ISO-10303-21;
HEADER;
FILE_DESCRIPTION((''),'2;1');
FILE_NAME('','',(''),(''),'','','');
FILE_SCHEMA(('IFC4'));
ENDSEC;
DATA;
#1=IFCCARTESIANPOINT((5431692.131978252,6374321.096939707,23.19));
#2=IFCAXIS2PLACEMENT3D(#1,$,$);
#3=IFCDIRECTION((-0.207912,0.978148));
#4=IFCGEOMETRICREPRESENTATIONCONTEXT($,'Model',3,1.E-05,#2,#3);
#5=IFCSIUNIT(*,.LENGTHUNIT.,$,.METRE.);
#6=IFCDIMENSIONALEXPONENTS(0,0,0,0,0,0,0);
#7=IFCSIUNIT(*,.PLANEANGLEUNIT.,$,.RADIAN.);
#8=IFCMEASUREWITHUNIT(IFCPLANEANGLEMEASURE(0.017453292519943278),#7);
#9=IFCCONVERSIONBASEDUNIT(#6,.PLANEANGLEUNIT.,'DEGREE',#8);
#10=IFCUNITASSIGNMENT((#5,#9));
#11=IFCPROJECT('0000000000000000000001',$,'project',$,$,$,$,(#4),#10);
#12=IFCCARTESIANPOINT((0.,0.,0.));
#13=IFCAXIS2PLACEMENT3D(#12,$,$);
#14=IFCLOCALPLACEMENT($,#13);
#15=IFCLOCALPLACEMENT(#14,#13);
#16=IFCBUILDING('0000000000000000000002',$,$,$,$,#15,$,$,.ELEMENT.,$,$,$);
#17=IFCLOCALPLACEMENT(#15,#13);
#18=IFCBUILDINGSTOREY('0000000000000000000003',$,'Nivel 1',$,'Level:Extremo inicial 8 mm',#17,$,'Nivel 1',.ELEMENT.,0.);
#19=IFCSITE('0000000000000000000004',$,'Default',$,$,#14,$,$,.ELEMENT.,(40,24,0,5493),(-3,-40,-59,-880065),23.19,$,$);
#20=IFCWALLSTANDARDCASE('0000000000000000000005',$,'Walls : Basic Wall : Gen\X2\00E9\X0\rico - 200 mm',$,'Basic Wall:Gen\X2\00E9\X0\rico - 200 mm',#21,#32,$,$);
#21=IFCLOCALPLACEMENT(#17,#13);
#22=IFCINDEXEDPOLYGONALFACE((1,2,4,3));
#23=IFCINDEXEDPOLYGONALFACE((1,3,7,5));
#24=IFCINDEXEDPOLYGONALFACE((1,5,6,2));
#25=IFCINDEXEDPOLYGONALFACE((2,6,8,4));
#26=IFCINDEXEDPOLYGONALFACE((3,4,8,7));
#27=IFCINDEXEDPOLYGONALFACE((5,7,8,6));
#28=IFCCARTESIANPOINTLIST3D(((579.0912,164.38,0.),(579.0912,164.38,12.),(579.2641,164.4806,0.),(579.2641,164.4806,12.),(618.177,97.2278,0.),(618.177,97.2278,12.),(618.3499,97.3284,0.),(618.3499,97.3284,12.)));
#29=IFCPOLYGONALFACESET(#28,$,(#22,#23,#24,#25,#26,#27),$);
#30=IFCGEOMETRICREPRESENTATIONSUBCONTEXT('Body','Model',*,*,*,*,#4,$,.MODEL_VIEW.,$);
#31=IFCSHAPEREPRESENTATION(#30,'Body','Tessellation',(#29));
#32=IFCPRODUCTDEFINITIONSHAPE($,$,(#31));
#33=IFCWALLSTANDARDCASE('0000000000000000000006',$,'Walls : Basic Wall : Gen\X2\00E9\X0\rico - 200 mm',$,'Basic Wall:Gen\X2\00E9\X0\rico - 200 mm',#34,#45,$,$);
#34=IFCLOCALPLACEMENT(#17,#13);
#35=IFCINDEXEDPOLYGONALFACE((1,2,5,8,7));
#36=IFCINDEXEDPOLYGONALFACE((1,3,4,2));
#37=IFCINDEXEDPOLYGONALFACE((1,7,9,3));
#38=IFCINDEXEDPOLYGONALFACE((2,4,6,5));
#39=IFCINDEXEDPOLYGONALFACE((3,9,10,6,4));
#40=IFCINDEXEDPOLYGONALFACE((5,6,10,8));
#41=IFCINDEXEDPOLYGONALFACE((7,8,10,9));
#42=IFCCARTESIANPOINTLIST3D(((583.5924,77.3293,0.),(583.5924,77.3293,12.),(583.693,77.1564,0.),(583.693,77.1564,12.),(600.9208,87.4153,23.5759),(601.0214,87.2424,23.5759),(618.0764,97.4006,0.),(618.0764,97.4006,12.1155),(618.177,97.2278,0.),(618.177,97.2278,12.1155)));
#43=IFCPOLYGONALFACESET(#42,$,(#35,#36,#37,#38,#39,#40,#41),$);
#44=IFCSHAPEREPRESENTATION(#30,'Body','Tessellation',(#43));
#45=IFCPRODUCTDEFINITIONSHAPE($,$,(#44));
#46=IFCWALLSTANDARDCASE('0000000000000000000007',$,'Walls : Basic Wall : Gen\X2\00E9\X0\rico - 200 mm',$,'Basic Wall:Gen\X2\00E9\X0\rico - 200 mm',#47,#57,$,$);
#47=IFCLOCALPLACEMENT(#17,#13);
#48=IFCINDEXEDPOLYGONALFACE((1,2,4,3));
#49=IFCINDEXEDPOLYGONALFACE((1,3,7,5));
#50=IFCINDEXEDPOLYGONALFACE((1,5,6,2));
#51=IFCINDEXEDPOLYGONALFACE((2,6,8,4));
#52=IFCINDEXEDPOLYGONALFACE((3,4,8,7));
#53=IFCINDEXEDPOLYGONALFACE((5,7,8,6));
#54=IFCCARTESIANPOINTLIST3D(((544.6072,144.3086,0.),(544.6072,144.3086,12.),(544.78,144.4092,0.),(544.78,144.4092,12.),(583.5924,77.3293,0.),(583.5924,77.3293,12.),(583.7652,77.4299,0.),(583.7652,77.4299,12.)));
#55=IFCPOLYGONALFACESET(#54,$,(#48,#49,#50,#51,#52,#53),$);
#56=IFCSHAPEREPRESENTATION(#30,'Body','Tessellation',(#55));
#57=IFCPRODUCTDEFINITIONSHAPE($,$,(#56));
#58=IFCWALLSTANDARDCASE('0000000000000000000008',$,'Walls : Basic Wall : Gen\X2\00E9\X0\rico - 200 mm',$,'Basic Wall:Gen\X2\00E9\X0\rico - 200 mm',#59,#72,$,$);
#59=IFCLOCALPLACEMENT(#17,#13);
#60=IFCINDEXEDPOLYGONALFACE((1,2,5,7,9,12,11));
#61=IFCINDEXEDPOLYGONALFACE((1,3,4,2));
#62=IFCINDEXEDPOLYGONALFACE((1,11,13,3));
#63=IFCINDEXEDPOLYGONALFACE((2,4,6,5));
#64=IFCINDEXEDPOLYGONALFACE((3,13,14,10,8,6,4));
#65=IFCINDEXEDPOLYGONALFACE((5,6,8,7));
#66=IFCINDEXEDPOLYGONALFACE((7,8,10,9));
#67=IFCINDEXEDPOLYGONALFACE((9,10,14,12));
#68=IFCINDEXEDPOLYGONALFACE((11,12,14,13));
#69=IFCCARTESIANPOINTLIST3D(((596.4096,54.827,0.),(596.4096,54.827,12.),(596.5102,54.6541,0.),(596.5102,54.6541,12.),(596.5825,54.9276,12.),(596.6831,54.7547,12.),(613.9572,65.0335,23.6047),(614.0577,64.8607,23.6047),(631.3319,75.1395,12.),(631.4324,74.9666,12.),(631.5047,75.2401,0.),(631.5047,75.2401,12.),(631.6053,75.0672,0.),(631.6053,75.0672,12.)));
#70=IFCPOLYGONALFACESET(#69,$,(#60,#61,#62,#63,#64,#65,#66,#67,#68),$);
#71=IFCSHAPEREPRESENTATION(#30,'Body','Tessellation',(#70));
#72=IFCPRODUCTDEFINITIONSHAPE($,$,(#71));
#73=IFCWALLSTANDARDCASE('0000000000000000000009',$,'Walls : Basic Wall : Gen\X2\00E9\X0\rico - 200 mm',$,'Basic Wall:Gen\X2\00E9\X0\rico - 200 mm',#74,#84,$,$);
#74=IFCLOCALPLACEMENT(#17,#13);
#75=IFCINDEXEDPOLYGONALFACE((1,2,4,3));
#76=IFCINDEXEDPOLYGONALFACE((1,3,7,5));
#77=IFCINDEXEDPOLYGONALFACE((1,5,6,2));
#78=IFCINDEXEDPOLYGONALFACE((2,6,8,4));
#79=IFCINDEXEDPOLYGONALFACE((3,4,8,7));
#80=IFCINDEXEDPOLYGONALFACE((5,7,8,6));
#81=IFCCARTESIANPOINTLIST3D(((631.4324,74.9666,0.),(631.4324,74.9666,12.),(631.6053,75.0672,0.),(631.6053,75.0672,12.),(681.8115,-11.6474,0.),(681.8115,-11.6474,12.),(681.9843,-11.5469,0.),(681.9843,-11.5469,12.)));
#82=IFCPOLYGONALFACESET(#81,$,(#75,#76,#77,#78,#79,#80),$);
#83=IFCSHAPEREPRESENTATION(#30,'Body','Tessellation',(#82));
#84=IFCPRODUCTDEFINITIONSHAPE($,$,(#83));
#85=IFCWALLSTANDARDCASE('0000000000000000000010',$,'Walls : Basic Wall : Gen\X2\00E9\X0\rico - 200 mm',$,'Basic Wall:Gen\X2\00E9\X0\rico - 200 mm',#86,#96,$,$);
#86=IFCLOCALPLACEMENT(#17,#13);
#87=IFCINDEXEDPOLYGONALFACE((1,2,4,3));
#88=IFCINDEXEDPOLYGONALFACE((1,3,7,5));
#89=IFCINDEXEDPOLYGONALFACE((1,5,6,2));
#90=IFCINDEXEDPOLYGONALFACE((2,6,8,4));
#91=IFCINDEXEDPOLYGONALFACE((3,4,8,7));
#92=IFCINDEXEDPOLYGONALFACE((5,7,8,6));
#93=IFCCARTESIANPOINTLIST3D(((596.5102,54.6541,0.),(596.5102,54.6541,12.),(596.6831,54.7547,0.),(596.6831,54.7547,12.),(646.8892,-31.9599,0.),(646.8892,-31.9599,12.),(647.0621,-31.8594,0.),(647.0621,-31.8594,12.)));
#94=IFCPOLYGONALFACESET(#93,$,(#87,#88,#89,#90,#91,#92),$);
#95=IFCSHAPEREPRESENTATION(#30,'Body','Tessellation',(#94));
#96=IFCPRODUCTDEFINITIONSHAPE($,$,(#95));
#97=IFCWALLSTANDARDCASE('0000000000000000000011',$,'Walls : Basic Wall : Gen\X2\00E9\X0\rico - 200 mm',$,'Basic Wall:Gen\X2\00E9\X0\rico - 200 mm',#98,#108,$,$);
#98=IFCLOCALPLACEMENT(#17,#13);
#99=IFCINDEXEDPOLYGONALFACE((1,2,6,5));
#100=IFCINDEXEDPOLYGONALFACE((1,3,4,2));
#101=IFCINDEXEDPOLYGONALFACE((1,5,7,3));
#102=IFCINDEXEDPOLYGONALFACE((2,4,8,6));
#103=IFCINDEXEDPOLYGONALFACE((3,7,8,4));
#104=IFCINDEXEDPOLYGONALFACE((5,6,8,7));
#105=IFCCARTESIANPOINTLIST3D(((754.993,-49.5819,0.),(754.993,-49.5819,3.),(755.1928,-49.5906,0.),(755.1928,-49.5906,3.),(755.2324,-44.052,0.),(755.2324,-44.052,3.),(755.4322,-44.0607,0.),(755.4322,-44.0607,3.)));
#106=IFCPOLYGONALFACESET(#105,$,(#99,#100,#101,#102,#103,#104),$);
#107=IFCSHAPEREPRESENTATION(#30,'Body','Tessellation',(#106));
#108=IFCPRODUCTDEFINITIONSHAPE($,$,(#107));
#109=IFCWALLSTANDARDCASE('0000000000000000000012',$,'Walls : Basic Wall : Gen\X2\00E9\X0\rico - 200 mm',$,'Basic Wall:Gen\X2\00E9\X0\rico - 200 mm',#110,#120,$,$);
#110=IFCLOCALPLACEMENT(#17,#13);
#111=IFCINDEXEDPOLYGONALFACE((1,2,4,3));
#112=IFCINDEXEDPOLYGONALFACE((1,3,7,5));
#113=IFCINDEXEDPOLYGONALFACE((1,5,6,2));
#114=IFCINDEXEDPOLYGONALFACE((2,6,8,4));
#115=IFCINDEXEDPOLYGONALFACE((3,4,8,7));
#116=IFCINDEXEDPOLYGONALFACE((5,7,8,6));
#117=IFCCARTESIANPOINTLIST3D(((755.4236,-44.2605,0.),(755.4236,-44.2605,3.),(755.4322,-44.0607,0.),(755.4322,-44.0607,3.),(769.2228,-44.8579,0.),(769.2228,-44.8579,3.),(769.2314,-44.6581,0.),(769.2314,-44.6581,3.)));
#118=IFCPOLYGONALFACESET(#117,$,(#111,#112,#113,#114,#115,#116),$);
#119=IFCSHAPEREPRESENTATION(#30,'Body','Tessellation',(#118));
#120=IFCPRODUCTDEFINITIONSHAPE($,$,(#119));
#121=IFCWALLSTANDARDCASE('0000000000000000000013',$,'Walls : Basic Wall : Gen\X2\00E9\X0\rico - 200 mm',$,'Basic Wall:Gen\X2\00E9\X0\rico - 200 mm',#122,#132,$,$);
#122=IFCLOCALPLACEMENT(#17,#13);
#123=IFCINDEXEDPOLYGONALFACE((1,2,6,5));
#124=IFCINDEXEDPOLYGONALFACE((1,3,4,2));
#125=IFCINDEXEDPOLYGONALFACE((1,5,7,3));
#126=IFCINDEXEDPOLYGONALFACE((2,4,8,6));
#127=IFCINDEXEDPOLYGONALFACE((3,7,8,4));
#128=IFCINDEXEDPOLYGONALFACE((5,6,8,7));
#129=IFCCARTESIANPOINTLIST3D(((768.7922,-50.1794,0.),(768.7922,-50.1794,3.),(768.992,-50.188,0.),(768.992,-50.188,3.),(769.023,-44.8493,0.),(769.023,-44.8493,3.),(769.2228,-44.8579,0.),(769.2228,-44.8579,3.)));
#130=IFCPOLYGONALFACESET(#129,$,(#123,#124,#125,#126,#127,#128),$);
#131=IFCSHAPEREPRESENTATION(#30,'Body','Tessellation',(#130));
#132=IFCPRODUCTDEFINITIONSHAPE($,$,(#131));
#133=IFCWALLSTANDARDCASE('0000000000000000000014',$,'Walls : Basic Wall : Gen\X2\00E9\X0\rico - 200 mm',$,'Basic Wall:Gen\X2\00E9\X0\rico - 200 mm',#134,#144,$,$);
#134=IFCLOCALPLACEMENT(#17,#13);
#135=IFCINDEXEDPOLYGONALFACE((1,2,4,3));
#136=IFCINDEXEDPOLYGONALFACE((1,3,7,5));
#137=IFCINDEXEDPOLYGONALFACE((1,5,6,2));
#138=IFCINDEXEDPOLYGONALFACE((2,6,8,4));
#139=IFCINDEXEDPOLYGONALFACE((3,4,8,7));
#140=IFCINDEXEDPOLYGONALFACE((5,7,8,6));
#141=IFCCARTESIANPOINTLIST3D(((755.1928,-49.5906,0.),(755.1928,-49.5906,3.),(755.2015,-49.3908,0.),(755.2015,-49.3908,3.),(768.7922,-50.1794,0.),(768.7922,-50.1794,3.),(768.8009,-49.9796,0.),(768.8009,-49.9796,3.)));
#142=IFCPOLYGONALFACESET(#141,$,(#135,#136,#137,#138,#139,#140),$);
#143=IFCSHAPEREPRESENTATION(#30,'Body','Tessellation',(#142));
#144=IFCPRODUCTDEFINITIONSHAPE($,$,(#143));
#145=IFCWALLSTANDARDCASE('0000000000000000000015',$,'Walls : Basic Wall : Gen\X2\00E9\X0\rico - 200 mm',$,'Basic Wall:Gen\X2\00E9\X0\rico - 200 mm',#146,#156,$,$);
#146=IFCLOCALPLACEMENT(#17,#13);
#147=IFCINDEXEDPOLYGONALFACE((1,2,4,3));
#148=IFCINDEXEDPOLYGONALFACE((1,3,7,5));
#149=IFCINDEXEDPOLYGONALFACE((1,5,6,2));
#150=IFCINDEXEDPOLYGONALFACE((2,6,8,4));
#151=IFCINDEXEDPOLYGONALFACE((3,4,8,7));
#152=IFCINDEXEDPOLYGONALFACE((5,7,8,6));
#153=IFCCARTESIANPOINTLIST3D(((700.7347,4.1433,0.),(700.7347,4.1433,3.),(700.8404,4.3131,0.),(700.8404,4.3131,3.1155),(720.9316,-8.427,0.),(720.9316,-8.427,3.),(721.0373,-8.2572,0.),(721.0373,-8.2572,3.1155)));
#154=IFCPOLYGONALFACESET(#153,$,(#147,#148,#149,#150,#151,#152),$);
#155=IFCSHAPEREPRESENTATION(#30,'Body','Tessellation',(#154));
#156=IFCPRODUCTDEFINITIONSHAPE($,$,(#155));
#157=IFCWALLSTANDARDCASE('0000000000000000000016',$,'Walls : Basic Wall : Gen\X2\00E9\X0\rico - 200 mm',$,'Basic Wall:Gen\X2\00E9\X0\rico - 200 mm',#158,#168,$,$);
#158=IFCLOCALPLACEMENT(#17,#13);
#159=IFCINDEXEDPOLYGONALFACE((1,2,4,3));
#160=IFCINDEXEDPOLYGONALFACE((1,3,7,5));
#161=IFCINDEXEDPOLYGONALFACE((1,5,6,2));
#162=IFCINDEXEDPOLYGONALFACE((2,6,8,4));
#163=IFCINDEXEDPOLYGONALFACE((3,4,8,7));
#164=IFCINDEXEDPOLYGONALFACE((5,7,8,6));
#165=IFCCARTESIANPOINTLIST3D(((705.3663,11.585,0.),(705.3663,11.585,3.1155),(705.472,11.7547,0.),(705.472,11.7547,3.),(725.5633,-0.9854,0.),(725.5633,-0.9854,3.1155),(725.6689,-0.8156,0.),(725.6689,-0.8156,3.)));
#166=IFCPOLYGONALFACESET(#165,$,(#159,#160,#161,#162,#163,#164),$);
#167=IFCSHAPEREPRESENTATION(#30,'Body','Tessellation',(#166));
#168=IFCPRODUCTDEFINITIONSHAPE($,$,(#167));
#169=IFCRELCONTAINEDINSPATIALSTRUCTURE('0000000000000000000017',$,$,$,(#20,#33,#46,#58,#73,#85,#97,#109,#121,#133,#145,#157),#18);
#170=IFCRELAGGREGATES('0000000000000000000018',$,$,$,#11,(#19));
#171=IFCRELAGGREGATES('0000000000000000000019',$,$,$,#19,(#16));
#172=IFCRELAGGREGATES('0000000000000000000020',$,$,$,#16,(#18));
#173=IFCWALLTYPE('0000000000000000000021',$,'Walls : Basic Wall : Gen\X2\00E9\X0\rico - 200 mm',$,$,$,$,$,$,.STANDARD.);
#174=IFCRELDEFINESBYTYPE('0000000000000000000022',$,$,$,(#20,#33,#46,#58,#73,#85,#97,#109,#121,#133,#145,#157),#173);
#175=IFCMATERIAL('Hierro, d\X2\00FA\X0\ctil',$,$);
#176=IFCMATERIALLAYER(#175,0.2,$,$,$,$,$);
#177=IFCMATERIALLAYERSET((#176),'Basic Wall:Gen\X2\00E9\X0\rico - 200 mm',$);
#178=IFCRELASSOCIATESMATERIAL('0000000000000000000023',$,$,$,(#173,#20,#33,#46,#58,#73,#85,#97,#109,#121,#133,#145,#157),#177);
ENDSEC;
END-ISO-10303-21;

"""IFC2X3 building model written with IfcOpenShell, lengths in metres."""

from ifc_helpers import new_model, entity, si_unit, converted_unit, direction, frame, frame_2d, origin, place, context, subcontext, project, spatial, polyline, rectangle, extrude, clip, bounded_halfspace, material, layer, layer_set, layer_usage, type_object, element, save


model = new_model("IFC2X3")

# Units and contexts
model_context = context("Model", 3, precision=1e-05, world=frame((5431692.131978252, 6374321.096939707, 23.19)), true_north=direction((-0.207912, 0.978148)))
body_context = subcontext(model_context, "Body", "Model", "MODEL_VIEW")
ifc_project = project(units=[si_unit("LENGTHUNIT", "METRE"), converted_unit("PLANEANGLEUNIT", "DEGREE", entity("IfcPlaneAngleMeasure", 0.017453292519943278), si_unit("PLANEANGLEUNIT", "RADIAN"), dimensions=[0, 0, 0, 0, 0, 0, 0])], contexts=[model_context])

# Site, building, storey
site_placement = place(None, origin())
site = spatial("IfcSite", under=ifc_project, at=site_placement, Name="Default", CompositionType="ELEMENT", RefLatitude=(40, 24, 0, 5493), RefLongitude=(-3, -40, -59, -880065), RefElevation=23.19)
building_placement = place(site_placement, origin())
building = spatial("IfcBuilding", under=site, at=building_placement, CompositionType="ELEMENT")
storey_placement = place(building_placement, origin())
storey = spatial("IfcBuildingStorey", under=building, at=storey_placement, Name="Nivel 1", ObjectType="Level:Extremo inicial 8 mm", LongName="Nivel 1", CompositionType="ELEMENT", Elevation=0.0)

# Walls
ifc_material_1 = material(Name="Hierro, dúctil")
ifc_layer_1 = layer(ifc_material_1, 0.2)
ifc_layer_set_1 = layer_set([ifc_layer_1], Name="Basic Wall:Genérico - 200 mm")
ifc_layer_usage_1 = layer_usage(ifc_layer_set_1, "AXIS2", "NEGATIVE", 0.1)
wall_type = type_object("IfcWallType", Name="Walls : Basic Wall : Genérico - 200 mm", PredefinedType="STANDARD", material=ifc_layer_set_1)
wall_1_placement = place(storey_placement, frame((579.1776, 164.4303, 0.0), z_axis=(0.0, 0.0, 1.0), x_axis=(0.503042, -0.864262, 0.0)))
element("IfcWallStandardCase", 1, at=wall_1_placement, inside=storey, type_object=wall_type, material=ifc_layer_usage_1, Name="Walls : Basic Wall : Genérico - 200 mm", ObjectType="Basic Wall:Genérico - 200 mm", context=body_context, shape_type="SweptSolid", body=[
    extrude(rectangle(XDim=77.6989, YDim=0.2, at=frame_2d((38.8494, 0.0), x_axis=(-1.0, 0.0))), origin(), (0.0, 0.0, 1.0), 12.0),
])
ifc_layer_usage_2 = layer_usage(ifc_layer_set_1, "AXIS2", "NEGATIVE", 0.1)
wall_2_placement = place(storey_placement, frame((618.1267, 97.3142, 0.0), z_axis=(0.0, 0.0, 1.0), x_axis=(-0.864262, -0.503042, 0.0)))
element("IfcWallStandardCase", 2, at=wall_2_placement, inside=storey, type_object=wall_type, material=ifc_layer_usage_2, Name="Walls : Basic Wall : Genérico - 200 mm", ObjectType="Basic Wall:Genérico - 200 mm", context=body_context, shape_type="Clipping", body=[
    clip(clip(extrude(rectangle(XDim=39.9, YDim=0.2, at=frame_2d((19.95, 0.0), x_axis=(-1.0, 0.0))), origin(), (0.0, 0.0, 1.0), 23.5759), bounded_halfspace(frame((0.0, -0.1, 12.1155), z_axis=(-0.5, 0.0, 0.866025), x_axis=(0.0, -1.0, 0.0)), False, frame((0.0, -0.1, 12.1155)), polyline([(0.0, 0.0), (19.85, 0.0), (19.85, 0.2), (0.0, 0.2), (0.0, 0.0)]))), bounded_halfspace(frame((19.85, -0.1, 23.5759), z_axis=(0.5, 0.0, 0.866025), x_axis=(0.0, 1.0, 0.0)), False, frame((19.85, -0.1, 23.5759)), polyline([(0.0, 0.0), (20.05, 0.0), (20.05, 0.2), (0.0, 0.2), (0.0, 0.0)]))),
])
ifc_layer_usage_3 = layer_usage(ifc_layer_set_1, "AXIS2", "NEGATIVE", 0.1)
wall_3_placement = place(storey_placement, frame((583.6788, 77.3796, 0.0), z_axis=(0.0, 0.0, 1.0), x_axis=(-0.503042, 0.864262, 0.0)))
element("IfcWallStandardCase", 3, at=wall_3_placement, inside=storey, type_object=wall_type, material=ifc_layer_usage_3, Name="Walls : Basic Wall : Genérico - 200 mm", ObjectType="Basic Wall:Genérico - 200 mm", context=body_context, shape_type="SweptSolid", body=[
    extrude(rectangle(XDim=77.4989, YDim=0.2, at=frame_2d((38.7494, 0.0), x_axis=(-1.0, 0.0))), origin(), (0.0, 0.0, 1.0), 12.0),
])
ifc_layer_usage_4 = layer_usage(ifc_layer_set_1, "AXIS2", "NEGATIVE", 0.1)
wall_4_placement = place(storey_placement, frame((596.4599, 54.7406, 0.0), z_axis=(0.0, 0.0, 1.0), x_axis=(0.864412, 0.502785, 0.0)))
element("IfcWallStandardCase", 4, at=wall_4_placement, inside=storey, type_object=wall_type, material=ifc_layer_usage_4, Name="Walls : Basic Wall : Genérico - 200 mm", ObjectType="Basic Wall:Genérico - 200 mm", context=body_context, shape_type="Clipping", body=[
    clip(clip(clip(clip(extrude(rectangle(XDim=40.6, YDim=0.2, at=frame_2d((20.3, 0.0), x_axis=(-1.0, 0.0))), origin(), (0.0, 0.0, 1.0), 23.6047), bounded_halfspace(frame((20.3, -0.1, 23.6047), z_axis=(0.5, 0.0, 0.866025), x_axis=(0.0, 1.0, 0.0)), False, frame((20.3, -0.1, 23.6047)), polyline([(0.0, 0.0), (20.1, 0.0), (20.1, 0.2), (0.0, 0.2), (0.0, 0.0)]))), bounded_halfspace(frame((0.2, -0.1, 12.0), z_axis=(-0.5, 0.0, 0.866025), x_axis=(0.0, -1.0, 0.0)), False, frame((0.2, -0.1, 12.0)), polyline([(0.0, 0.0), (20.1, 0.0), (20.1, 0.2), (0.0, 0.2), (0.0, 0.0)]))), bounded_halfspace(frame((40.4, -0.1, 12.0), z_axis=(0.0, 0.0, 1.0), x_axis=(0.0, 1.0, 0.0)), False, frame((40.4, -0.1, 12.0)), polyline([(0.0, 0.0), (0.2, 0.0), (0.2, 0.2), (0.0, 0.2), (0.0, 0.0)]))), bounded_halfspace(frame((0.0, -0.1, 12.0), z_axis=(0.0, 0.0, 1.0), x_axis=(0.0, 1.0, 0.0)), False, frame((0.0, -0.1, 12.0)), polyline([(0.0, 0.0), (0.2, 0.0), (0.2, 0.2), (0.0, 0.2), (0.0, 0.0)]))),
])
ifc_layer_usage_5 = layer_usage(ifc_layer_set_1, "AXIS2", "NEGATIVE", 0.1)
wall_5_placement = place(storey_placement, frame((631.5189, 75.0169, 0.0), z_axis=(0.0, 0.0, 1.0), x_axis=(0.502785, -0.864412, 0.0)))
element("IfcWallStandardCase", 5, at=wall_5_placement, inside=storey, type_object=wall_type, material=ifc_layer_usage_5, Name="Walls : Basic Wall : Genérico - 200 mm", ObjectType="Basic Wall:Genérico - 200 mm", context=body_context, shape_type="SweptSolid", body=[
    extrude(rectangle(XDim=100.2, YDim=0.2, at=frame_2d((50.1, 0.0), x_axis=(-1.0, 0.0))), origin(), (0.0, 0.0, 1.0), 12.0),
])
ifc_layer_usage_6 = layer_usage(ifc_layer_set_1, "AXIS2", "NEGATIVE", 0.1)
wall_6_placement = place(storey_placement, frame((646.9757, -31.9096, 0.0), z_axis=(0.0, 0.0, 1.0), x_axis=(-0.502785, 0.864412, 0.0)))
element("IfcWallStandardCase", 6, at=wall_6_placement, inside=storey, type_object=wall_type, material=ifc_layer_usage_6, Name="Walls : Basic Wall : Genérico - 200 mm", ObjectType="Basic Wall:Genérico - 200 mm", context=body_context, shape_type="SweptSolid", body=[
    extrude(rectangle(XDim=100.2, YDim=0.2, at=frame_2d((50.1, 0.0), x_axis=(-1.0, 0.0))), origin(), (0.0, 0.0, 1.0), 12.0),
])
ifc_layer_usage_7 = layer_usage(ifc_layer_set_1, "AXIS2", "NEGATIVE", 0.1)
wall_7_placement = place(storey_placement, frame((755.0929, -49.5863, 0.0), z_axis=(0.0, 0.0, 1.0), x_axis=(0.043255, 0.999064, 0.0)))
element("IfcWallStandardCase", 7, at=wall_7_placement, inside=storey, type_object=wall_type, material=ifc_layer_usage_7, Name="Walls : Basic Wall : Genérico - 200 mm", ObjectType="Basic Wall:Genérico - 200 mm", context=body_context, shape_type="SweptSolid", body=[
    extrude(rectangle(XDim=5.5351, YDim=0.2, at=frame_2d((2.7675, 0.0), x_axis=(-1.0, 0.0))), origin(), (0.0, 0.0, 1.0), 3.0),
])
ifc_layer_usage_8 = layer_usage(ifc_layer_set_1, "AXIS2", "NEGATIVE", 0.1)
wall_8_placement = place(storey_placement, frame((755.4279, -44.1606, 0.0), z_axis=(0.0, 0.0, 1.0), x_axis=(0.999064, -0.043255, 0.0)))
element("IfcWallStandardCase", 8, at=wall_8_placement, inside=storey, type_object=wall_type, material=ifc_layer_usage_8, Name="Walls : Basic Wall : Genérico - 200 mm", ObjectType="Basic Wall:Genérico - 200 mm", context=body_context, shape_type="SweptSolid", body=[
    extrude(rectangle(XDim=13.8122, YDim=0.2, at=frame_2d((6.9061, 0.0), x_axis=(-1.0, 0.0))), origin(), (0.0, 0.0, 1.0), 3.0),
])
ifc_layer_usage_9 = layer_usage(ifc_layer_set_1, "AXIS2", "NEGATIVE", 0.1)
wall_9_placement = place(storey_placement, frame((769.1229, -44.8536, 0.0), z_axis=(0.0, 0.0, 1.0), x_axis=(-0.043255, -0.999064, 0.0)))
element("IfcWallStandardCase", 9, at=wall_9_placement, inside=storey, type_object=wall_type, material=ifc_layer_usage_9, Name="Walls : Basic Wall : Genérico - 200 mm", ObjectType="Basic Wall:Genérico - 200 mm", context=body_context, shape_type="SweptSolid", body=[
    extrude(rectangle(XDim=5.3351, YDim=0.2, at=frame_2d((2.6675, 0.0), x_axis=(-1.0, 0.0))), origin(), (0.0, 0.0, 1.0), 3.0),
])
ifc_layer_usage_10 = layer_usage(ifc_layer_set_1, "AXIS2", "NEGATIVE", 0.1)
wall_10_placement = place(storey_placement, frame((768.7965, -50.0795, 0.0), z_axis=(0.0, 0.0, 1.0), x_axis=(-0.999064, 0.043255, 0.0)))
element("IfcWallStandardCase", 10, at=wall_10_placement, inside=storey, type_object=wall_type, material=ifc_layer_usage_10, Name="Walls : Basic Wall : Genérico - 200 mm", ObjectType="Basic Wall:Genérico - 200 mm", context=body_context, shape_type="SweptSolid", body=[
    extrude(rectangle(XDim=13.6122, YDim=0.2, at=frame_2d((6.8061, 0.0), x_axis=(-1.0, 0.0))), origin(), (0.0, 0.0, 1.0), 3.0),
])
ifc_layer_usage_11 = layer_usage(ifc_layer_set_1, "AXIS2", "NEGATIVE", 0.1)
wall_11_placement = place(storey_placement, frame((700.7876, 4.2282, 0.0), z_axis=(0.0, 0.0, 1.0), x_axis=(0.848993, -0.528404, 0.0)))
element("IfcWallStandardCase", 11, at=wall_11_placement, inside=storey, type_object=wall_type, material=ifc_layer_usage_11, Name="Walls : Basic Wall : Genérico - 200 mm", ObjectType="Basic Wall:Genérico - 200 mm", context=body_context, shape_type="Clipping", body=[
    clip(extrude(rectangle(XDim=23.7893, YDim=0.2, at=frame_2d((11.8946, 0.0), x_axis=(-1.0, 0.0))), origin(), (0.0, 0.0, 1.0), 3.1155), bounded_halfspace(frame((0.0, -0.1, 3.0), z_axis=(0.0, -0.5, 0.866025), x_axis=(1.0, 0.0, 0.0)), False, frame((0.0, -0.1, 3.0)), polyline([(0.0, 0.0), (23.7893, 0.0), (23.7893, 0.2), (23.5893, 0.2), (0.2, 0.2), (0.0, 0.2), (0.0, 0.0)]))),
])
ifc_layer_usage_12 = layer_usage(ifc_layer_set_1, "AXIS2", "NEGATIVE", 0.1)
wall_12_placement = place(storey_placement, frame((725.6161, -0.9005, 0.0), z_axis=(0.0, 0.0, 1.0), x_axis=(-0.848993, 0.528404, 0.0)))
element("IfcWallStandardCase", 12, at=wall_12_placement, inside=storey, type_object=wall_type, material=ifc_layer_usage_12, Name="Walls : Basic Wall : Genérico - 200 mm", ObjectType="Basic Wall:Genérico - 200 mm", context=body_context, shape_type="Clipping", body=[
    clip(extrude(rectangle(XDim=23.7893, YDim=0.2, at=frame_2d((11.8946, 0.0), x_axis=(-1.0, 0.0))), origin(), (0.0, 0.0, 1.0), 3.1155), bounded_halfspace(frame((0.0, -0.1, 3.0), z_axis=(0.0, -0.5, 0.866025), x_axis=(1.0, 0.0, 0.0)), False, frame((0.0, -0.1, 3.0)), polyline([(0.0, 0.0), (23.7893, 0.0), (23.7893, 0.2), (23.5893, 0.2), (0.2, 0.2), (0.0, 0.2), (0.0, 0.0)]))),
])

save(model, "model.ifc")
